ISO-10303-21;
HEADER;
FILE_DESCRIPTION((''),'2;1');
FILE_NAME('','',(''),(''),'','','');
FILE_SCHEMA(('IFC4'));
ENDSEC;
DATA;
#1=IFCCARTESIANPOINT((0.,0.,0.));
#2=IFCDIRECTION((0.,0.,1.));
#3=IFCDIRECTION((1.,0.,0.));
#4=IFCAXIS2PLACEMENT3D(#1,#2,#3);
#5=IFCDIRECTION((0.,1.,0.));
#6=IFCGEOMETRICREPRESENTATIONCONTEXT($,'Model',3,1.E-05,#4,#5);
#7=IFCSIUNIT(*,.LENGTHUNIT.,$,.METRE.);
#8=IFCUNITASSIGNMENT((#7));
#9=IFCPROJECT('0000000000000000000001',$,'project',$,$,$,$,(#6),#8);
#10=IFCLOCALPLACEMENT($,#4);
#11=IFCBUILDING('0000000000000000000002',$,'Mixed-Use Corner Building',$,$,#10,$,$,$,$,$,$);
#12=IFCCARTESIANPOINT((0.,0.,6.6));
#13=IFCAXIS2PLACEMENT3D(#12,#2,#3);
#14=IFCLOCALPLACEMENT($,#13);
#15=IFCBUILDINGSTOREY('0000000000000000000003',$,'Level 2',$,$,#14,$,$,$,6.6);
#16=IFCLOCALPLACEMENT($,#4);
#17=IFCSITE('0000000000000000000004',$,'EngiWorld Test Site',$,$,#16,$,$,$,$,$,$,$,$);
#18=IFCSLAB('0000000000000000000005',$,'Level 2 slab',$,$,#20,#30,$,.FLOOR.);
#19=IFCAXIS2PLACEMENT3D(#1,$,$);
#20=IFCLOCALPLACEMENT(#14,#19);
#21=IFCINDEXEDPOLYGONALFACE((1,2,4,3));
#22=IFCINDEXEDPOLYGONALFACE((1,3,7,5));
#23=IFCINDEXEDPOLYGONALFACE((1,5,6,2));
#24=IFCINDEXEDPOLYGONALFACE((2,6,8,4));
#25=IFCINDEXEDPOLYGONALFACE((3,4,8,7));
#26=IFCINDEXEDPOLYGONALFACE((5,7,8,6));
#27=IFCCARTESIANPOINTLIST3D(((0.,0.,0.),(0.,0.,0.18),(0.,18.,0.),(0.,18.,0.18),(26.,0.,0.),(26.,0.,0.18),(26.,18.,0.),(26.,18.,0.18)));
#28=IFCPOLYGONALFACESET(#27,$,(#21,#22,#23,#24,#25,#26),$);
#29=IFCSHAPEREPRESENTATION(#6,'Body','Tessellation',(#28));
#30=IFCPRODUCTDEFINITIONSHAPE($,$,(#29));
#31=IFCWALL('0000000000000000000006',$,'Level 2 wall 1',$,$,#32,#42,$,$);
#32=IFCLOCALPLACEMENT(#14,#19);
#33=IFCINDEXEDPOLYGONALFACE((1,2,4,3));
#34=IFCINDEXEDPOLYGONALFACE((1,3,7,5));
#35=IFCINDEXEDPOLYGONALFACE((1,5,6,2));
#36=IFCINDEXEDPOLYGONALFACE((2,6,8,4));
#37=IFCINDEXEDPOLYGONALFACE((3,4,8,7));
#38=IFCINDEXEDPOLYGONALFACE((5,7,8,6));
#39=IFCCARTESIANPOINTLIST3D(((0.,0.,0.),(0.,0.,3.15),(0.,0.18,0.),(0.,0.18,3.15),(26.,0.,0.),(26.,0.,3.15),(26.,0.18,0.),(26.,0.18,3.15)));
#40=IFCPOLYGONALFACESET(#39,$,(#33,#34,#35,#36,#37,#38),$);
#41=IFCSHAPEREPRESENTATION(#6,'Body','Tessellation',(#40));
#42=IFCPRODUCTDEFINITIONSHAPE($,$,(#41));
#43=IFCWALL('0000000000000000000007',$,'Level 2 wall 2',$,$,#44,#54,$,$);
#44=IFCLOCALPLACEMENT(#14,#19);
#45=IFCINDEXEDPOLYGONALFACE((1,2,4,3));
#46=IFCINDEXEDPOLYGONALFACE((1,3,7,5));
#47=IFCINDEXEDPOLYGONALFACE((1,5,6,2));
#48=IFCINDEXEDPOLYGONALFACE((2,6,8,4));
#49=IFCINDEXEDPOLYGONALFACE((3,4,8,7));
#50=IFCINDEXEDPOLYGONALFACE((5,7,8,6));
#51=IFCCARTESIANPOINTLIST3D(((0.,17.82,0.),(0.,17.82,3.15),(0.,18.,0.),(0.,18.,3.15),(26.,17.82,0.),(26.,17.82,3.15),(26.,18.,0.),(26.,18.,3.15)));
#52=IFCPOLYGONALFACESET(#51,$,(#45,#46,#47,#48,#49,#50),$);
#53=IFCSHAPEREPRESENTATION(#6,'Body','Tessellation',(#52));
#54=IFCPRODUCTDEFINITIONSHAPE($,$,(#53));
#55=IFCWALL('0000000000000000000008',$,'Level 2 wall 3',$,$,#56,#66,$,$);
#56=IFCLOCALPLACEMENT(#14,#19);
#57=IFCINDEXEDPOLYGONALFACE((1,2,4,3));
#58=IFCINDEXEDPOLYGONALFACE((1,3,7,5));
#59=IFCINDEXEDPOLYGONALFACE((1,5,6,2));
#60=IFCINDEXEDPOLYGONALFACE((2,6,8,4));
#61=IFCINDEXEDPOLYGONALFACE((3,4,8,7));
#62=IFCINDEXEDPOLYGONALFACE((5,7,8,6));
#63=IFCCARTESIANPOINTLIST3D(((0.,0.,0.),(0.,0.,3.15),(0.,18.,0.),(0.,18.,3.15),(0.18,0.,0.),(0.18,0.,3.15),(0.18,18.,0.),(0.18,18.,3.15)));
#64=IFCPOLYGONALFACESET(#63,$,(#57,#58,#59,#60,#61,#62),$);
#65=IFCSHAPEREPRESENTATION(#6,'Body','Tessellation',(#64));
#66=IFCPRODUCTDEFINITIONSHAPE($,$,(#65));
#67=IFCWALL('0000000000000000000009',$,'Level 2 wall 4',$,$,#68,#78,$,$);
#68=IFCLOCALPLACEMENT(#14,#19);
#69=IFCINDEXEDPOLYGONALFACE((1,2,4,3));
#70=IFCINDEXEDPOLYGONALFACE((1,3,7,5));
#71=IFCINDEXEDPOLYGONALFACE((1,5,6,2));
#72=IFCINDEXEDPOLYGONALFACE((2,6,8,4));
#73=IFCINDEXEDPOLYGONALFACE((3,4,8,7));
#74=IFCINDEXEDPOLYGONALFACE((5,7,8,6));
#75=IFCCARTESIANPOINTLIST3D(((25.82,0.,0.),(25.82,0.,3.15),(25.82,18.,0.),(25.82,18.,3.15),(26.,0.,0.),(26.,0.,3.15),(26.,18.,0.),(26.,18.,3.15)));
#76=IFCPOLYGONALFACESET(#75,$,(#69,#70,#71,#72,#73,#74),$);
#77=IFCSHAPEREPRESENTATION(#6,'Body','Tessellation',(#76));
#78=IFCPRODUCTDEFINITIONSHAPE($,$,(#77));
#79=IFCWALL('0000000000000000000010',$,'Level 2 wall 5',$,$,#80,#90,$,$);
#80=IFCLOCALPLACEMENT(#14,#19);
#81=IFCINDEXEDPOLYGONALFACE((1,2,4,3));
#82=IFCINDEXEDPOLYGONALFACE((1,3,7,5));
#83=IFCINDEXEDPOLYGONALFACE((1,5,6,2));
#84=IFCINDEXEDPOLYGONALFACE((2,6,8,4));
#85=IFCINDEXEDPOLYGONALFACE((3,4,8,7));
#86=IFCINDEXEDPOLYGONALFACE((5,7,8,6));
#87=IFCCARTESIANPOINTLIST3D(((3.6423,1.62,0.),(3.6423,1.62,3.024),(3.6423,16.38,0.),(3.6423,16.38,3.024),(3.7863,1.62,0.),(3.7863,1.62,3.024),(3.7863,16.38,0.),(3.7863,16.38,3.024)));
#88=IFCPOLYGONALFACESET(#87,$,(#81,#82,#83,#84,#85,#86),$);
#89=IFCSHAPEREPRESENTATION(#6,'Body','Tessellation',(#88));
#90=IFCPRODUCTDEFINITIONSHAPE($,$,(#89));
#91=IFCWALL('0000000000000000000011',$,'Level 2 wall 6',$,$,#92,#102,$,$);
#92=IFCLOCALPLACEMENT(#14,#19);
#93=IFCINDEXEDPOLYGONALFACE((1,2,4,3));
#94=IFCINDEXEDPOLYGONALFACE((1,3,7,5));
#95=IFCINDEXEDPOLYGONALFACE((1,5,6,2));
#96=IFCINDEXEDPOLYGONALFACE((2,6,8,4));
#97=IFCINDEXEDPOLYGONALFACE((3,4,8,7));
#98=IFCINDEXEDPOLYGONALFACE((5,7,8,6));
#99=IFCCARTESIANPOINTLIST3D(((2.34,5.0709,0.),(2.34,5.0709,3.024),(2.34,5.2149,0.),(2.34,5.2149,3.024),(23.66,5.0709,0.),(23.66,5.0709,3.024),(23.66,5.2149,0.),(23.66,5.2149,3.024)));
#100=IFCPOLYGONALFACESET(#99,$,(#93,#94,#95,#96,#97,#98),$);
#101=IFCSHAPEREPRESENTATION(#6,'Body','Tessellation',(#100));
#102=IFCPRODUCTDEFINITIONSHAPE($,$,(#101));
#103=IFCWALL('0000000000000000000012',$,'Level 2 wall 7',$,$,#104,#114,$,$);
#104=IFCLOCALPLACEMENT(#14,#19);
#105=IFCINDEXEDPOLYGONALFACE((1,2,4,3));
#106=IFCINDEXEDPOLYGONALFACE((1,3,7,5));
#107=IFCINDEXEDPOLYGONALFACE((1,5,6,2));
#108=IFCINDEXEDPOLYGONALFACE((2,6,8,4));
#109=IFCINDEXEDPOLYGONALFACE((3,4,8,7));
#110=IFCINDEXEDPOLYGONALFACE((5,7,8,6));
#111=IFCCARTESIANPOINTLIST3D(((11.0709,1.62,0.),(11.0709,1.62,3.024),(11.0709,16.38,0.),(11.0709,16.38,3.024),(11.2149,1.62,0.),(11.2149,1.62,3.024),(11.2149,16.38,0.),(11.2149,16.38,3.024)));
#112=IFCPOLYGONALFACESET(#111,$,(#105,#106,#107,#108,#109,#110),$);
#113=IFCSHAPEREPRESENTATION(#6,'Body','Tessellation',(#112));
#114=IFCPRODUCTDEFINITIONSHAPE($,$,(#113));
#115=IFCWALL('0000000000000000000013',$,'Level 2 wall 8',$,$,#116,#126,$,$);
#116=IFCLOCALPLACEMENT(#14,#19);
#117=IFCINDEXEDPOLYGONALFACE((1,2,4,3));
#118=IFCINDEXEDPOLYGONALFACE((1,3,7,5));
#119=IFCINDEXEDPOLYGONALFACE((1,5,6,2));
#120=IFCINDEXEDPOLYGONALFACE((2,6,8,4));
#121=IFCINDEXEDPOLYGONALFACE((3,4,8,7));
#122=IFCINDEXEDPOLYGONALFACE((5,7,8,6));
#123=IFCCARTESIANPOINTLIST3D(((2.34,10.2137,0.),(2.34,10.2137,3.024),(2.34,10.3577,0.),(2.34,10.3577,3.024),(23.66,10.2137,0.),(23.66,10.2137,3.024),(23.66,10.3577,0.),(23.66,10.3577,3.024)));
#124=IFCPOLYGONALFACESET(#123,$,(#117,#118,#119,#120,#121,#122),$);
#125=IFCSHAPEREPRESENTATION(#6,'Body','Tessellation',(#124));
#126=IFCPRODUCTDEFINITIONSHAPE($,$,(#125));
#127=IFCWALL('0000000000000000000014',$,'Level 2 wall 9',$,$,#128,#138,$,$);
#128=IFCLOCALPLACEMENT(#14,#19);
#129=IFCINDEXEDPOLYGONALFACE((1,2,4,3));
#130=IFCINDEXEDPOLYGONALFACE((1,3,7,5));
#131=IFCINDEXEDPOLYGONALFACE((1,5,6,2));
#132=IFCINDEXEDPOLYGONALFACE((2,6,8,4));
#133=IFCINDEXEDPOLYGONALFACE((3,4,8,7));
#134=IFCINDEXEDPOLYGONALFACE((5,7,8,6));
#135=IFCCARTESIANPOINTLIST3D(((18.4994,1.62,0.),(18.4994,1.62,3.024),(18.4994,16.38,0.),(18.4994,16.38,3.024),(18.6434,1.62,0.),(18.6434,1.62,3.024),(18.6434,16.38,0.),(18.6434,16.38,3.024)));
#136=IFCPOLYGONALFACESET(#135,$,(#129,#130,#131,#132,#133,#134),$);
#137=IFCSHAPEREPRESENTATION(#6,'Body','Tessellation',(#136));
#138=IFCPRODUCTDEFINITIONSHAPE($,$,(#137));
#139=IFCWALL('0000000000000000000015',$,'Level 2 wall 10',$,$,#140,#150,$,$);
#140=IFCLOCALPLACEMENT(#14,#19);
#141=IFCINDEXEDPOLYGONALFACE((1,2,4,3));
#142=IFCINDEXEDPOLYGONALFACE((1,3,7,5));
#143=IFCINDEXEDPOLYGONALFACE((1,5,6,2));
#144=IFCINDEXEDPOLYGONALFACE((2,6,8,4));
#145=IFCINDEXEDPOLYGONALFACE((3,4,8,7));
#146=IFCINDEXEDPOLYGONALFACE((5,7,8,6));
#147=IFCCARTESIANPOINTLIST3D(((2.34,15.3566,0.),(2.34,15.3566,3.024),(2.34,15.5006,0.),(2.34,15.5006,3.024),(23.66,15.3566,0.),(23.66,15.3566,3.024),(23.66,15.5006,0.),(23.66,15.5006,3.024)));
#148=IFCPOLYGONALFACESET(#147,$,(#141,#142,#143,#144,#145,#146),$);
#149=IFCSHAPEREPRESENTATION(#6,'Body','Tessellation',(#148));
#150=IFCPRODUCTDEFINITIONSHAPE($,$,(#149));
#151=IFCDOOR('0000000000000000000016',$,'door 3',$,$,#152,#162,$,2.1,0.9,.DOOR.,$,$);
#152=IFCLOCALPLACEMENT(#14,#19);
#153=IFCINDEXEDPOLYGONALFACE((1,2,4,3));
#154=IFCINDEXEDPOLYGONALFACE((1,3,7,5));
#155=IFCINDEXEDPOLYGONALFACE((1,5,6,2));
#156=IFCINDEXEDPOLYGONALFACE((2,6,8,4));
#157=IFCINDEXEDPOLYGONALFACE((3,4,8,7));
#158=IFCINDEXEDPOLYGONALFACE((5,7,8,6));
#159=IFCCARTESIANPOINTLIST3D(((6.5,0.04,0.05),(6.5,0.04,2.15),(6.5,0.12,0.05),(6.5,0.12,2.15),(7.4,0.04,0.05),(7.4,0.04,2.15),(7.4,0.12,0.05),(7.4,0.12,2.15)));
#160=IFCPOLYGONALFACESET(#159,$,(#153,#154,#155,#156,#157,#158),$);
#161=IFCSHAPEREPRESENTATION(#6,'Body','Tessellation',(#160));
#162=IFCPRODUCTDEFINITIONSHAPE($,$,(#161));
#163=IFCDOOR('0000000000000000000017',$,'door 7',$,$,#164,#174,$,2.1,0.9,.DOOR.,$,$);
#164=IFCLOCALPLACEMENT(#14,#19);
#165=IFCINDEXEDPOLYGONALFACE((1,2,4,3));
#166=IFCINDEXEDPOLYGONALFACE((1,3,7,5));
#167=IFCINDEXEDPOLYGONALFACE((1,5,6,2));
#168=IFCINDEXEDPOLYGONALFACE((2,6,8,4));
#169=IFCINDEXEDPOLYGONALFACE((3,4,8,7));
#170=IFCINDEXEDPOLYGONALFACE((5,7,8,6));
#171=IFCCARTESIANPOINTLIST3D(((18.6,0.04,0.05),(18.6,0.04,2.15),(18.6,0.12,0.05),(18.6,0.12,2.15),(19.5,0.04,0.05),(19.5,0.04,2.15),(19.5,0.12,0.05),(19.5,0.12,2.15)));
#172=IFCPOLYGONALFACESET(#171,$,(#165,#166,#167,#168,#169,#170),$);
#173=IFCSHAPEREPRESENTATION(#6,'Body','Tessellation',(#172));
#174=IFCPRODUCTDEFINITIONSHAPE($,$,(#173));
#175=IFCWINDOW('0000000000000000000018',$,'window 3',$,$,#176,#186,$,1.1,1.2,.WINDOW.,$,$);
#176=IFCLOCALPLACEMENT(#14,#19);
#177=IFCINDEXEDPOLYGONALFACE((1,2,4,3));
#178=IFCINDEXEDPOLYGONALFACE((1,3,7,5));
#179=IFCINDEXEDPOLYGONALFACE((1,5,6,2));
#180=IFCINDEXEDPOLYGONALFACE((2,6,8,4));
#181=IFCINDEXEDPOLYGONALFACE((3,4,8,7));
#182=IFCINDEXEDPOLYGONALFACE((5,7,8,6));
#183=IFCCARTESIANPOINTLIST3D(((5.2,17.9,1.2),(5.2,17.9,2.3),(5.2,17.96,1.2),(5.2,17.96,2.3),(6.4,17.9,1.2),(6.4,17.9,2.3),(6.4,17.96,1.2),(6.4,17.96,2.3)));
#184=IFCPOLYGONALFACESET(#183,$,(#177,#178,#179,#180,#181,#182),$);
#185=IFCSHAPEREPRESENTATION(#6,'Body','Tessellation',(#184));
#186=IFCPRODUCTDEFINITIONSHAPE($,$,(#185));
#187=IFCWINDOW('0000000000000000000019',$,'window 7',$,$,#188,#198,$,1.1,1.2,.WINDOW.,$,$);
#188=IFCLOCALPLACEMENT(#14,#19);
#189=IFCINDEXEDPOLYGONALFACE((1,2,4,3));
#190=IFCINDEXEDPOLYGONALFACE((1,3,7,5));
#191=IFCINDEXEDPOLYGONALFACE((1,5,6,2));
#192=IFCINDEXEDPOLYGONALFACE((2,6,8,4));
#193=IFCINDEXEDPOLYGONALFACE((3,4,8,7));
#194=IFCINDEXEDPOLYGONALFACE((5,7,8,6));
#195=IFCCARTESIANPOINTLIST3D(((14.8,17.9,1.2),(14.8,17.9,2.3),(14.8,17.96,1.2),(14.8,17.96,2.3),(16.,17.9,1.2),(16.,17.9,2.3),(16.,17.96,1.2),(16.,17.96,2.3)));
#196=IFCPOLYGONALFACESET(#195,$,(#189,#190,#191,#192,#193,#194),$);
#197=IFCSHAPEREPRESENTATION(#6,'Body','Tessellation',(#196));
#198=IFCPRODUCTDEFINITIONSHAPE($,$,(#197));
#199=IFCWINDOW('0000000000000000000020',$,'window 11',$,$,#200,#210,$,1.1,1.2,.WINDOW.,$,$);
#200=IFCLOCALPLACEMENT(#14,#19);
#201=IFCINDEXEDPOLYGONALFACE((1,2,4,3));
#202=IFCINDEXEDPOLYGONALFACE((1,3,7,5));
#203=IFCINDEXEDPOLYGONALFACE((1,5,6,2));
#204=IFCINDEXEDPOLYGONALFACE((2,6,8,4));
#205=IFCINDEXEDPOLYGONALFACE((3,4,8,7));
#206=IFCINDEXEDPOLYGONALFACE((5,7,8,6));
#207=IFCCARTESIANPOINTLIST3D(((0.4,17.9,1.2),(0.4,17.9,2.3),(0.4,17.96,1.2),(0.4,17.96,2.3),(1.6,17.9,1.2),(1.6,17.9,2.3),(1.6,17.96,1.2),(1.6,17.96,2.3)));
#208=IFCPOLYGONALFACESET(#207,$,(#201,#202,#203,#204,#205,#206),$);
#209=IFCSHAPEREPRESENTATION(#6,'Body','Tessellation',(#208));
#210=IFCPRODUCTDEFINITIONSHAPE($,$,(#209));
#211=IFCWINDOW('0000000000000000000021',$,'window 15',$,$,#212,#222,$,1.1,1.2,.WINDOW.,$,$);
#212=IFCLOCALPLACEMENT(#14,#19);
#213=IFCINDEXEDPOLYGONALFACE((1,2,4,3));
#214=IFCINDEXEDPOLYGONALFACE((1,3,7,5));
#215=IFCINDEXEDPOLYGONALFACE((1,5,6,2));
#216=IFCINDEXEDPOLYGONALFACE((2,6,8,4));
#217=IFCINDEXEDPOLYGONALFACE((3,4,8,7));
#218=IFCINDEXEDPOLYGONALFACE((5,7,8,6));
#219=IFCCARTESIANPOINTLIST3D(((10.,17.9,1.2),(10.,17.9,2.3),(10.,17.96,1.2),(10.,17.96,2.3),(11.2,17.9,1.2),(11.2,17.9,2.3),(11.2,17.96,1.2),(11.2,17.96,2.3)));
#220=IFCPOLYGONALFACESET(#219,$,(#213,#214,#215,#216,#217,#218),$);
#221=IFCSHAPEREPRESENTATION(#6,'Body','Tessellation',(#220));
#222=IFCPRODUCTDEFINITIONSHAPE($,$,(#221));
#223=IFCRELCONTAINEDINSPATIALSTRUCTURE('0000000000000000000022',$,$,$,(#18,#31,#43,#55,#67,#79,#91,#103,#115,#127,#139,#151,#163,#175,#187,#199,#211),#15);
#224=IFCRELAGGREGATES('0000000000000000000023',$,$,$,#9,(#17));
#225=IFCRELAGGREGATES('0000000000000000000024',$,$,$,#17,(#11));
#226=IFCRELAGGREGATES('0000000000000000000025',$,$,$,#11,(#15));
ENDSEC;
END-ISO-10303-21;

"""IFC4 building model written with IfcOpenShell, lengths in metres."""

from ifc_helpers import new_model, si_unit, direction, frame, origin_with_axes, origin_2d_with_axis, place, context, project, spatial, rectangle, extrude, element, save


model = new_model("IFC4")

# Units and contexts
model_context = context("Model", 3, precision=1e-05, world=origin_with_axes(), true_north=direction((0.0, 1.0, 0.0)))
ifc_project = project(units=[si_unit("LENGTHUNIT", "METRE")], contexts=[model_context])

# Site, building, storey
site_placement = place(None, origin_with_axes())
site = spatial("IfcSite", under=ifc_project, at=site_placement, Name="EngiWorld Test Site")
building_placement = place(None, origin_with_axes())
building = spatial("IfcBuilding", under=site, at=building_placement, Name="Mixed-Use Corner Building")
storey_placement = place(None, frame((0.0, 0.0, 6.6), z_axis=(0.0, 0.0, 1.0), x_axis=(1.0, 0.0, 0.0)))
storey = spatial("IfcBuildingStorey", under=building, at=storey_placement, Name="Level 2", Elevation=6.6)

# Slab
slab_placement = place(None, frame((13.0, 9.0, 6.6), z_axis=(0.0, 0.0, 1.0), x_axis=(1.0, 0.0, 0.0)))
element("IfcSlab", 1, at=slab_placement, inside=storey, Name="Level 2 slab", PredefinedType="FLOOR", context=model_context, shape_type="SweptSolid", body=[
    extrude(rectangle(XDim=26.0, YDim=18.0, at=origin_2d_with_axis()), origin_with_axes(), (0.0, 0.0, 1.0), 0.18),
])

# Walls
for number, where, z_axis, x_axis, name in (
    (2, (13.0, 0.09, 6.6), (0.0, 0.0, 1.0), (1.0, 0.0, 0.0), "Level 2 wall 1"),
    (3, (13.0, 17.91, 6.6), (0.0, 0.0, 1.0), (1.0, 0.0, 0.0), "Level 2 wall 2"),
):
    element("IfcWall", number, at=place(None, frame(where, z_axis=z_axis, x_axis=x_axis)), inside=storey, Name=name, context=model_context, shape_type="SweptSolid", body=[
        extrude(rectangle(XDim=26.0, YDim=0.18, at=origin_2d_with_axis()), origin_with_axes(), (0.0, 0.0, 1.0), 3.15),
    ])
for number, where, z_axis, x_axis, name in (
    (4, (0.09, 9.0, 6.6), (0.0, 0.0, 1.0), (1.0, 0.0, 0.0), "Level 2 wall 3"),
    (5, (25.91, 9.0, 6.6), (0.0, 0.0, 1.0), (1.0, 0.0, 0.0), "Level 2 wall 4"),
):
    element("IfcWall", number, at=place(None, frame(where, z_axis=z_axis, x_axis=x_axis)), inside=storey, Name=name, context=model_context, shape_type="SweptSolid", body=[
        extrude(rectangle(XDim=0.18, YDim=18.0, at=origin_2d_with_axis()), origin_with_axes(), (0.0, 0.0, 1.0), 3.15),
    ])
wall_1_placement = place(None, frame((3.7143, 9.0, 6.6), z_axis=(0.0, 0.0, 1.0), x_axis=(1.0, 0.0, 0.0)))
element("IfcWall", 6, at=wall_1_placement, inside=storey, Name="Level 2 wall 5", context=model_context, shape_type="SweptSolid", body=[
    extrude(rectangle(XDim=0.144, YDim=14.76, at=origin_2d_with_axis()), origin_with_axes(), (0.0, 0.0, 1.0), 3.024),
])
wall_2_placement = place(None, frame((13.0, 5.1429, 6.6), z_axis=(0.0, 0.0, 1.0), x_axis=(1.0, 0.0, 0.0)))
element("IfcWall", 7, at=wall_2_placement, inside=storey, Name="Level 2 wall 6", context=model_context, shape_type="SweptSolid", body=[
    extrude(rectangle(XDim=21.32, YDim=0.144, at=origin_2d_with_axis()), origin_with_axes(), (0.0, 0.0, 1.0), 3.024),
])
wall_3_placement = place(None, frame((11.1429, 9.0, 6.6), z_axis=(0.0, 0.0, 1.0), x_axis=(1.0, 0.0, 0.0)))
element("IfcWall", 8, at=wall_3_placement, inside=storey, Name="Level 2 wall 7", context=model_context, shape_type="SweptSolid", body=[
    extrude(rectangle(XDim=0.144, YDim=14.76, at=origin_2d_with_axis()), origin_with_axes(), (0.0, 0.0, 1.0), 3.024),
])
wall_4_placement = place(None, frame((13.0, 10.2857, 6.6), z_axis=(0.0, 0.0, 1.0), x_axis=(1.0, 0.0, 0.0)))
element("IfcWall", 9, at=wall_4_placement, inside=storey, Name="Level 2 wall 8", context=model_context, shape_type="SweptSolid", body=[
    extrude(rectangle(XDim=21.32, YDim=0.144, at=origin_2d_with_axis()), origin_with_axes(), (0.0, 0.0, 1.0), 3.024),
])
wall_5_placement = place(None, frame((18.5714, 9.0, 6.6), z_axis=(0.0, 0.0, 1.0), x_axis=(1.0, 0.0, 0.0)))
element("IfcWall", 10, at=wall_5_placement, inside=storey, Name="Level 2 wall 9", context=model_context, shape_type="SweptSolid", body=[
    extrude(rectangle(XDim=0.144, YDim=14.76, at=origin_2d_with_axis()), origin_with_axes(), (0.0, 0.0, 1.0), 3.024),
])
wall_6_placement = place(None, frame((13.0, 15.4286, 6.6), z_axis=(0.0, 0.0, 1.0), x_axis=(1.0, 0.0, 0.0)))
element("IfcWall", 11, at=wall_6_placement, inside=storey, Name="Level 2 wall 10", context=model_context, shape_type="SweptSolid", body=[
    extrude(rectangle(XDim=21.32, YDim=0.144, at=origin_2d_with_axis()), origin_with_axes(), (0.0, 0.0, 1.0), 3.024),
])

# Doors
for number, where, z_axis, x_axis, name in (
    (12, (6.95, 0.08, 6.65), (0.0, 0.0, 1.0), (1.0, 0.0, 0.0), "door 3"),
    (13, (19.05, 0.08, 6.65), (0.0, 0.0, 1.0), (1.0, 0.0, 0.0), "door 7"),
):
    element("IfcDoor", number, at=place(None, frame(where, z_axis=z_axis, x_axis=x_axis)), inside=storey, Name=name, OverallHeight=2.1, OverallWidth=0.9, PredefinedType="DOOR", context=model_context, shape_type="SweptSolid", body=[
        extrude(rectangle(XDim=0.9, YDim=0.08, at=origin_2d_with_axis()), origin_with_axes(), (0.0, 0.0, 1.0), 2.1),
    ])

# Windows
for number, where, z_axis, x_axis, name in (
    (14, (5.8, 17.93, 7.8), (0.0, 0.0, 1.0), (1.0, 0.0, 0.0), "window 3"),
    (15, (15.4, 17.93, 7.8), (0.0, 0.0, 1.0), (1.0, 0.0, 0.0), "window 7"),
    (16, (1.0, 17.93, 7.8), (0.0, 0.0, 1.0), (1.0, 0.0, 0.0), "window 11"),
    (17, (10.6, 17.93, 7.8), (0.0, 0.0, 1.0), (1.0, 0.0, 0.0), "window 15"),
):
    element("IfcWindow", number, at=place(None, frame(where, z_axis=z_axis, x_axis=x_axis)), inside=storey, Name=name, OverallHeight=1.1, OverallWidth=1.2, PredefinedType="WINDOW", context=model_context, shape_type="SweptSolid", body=[
        extrude(rectangle(XDim=1.2, YDim=0.06, at=origin_2d_with_axis()), origin_with_axes(), (0.0, 0.0, 1.0), 1.1),
    ])

save(model, "model.ifc")
